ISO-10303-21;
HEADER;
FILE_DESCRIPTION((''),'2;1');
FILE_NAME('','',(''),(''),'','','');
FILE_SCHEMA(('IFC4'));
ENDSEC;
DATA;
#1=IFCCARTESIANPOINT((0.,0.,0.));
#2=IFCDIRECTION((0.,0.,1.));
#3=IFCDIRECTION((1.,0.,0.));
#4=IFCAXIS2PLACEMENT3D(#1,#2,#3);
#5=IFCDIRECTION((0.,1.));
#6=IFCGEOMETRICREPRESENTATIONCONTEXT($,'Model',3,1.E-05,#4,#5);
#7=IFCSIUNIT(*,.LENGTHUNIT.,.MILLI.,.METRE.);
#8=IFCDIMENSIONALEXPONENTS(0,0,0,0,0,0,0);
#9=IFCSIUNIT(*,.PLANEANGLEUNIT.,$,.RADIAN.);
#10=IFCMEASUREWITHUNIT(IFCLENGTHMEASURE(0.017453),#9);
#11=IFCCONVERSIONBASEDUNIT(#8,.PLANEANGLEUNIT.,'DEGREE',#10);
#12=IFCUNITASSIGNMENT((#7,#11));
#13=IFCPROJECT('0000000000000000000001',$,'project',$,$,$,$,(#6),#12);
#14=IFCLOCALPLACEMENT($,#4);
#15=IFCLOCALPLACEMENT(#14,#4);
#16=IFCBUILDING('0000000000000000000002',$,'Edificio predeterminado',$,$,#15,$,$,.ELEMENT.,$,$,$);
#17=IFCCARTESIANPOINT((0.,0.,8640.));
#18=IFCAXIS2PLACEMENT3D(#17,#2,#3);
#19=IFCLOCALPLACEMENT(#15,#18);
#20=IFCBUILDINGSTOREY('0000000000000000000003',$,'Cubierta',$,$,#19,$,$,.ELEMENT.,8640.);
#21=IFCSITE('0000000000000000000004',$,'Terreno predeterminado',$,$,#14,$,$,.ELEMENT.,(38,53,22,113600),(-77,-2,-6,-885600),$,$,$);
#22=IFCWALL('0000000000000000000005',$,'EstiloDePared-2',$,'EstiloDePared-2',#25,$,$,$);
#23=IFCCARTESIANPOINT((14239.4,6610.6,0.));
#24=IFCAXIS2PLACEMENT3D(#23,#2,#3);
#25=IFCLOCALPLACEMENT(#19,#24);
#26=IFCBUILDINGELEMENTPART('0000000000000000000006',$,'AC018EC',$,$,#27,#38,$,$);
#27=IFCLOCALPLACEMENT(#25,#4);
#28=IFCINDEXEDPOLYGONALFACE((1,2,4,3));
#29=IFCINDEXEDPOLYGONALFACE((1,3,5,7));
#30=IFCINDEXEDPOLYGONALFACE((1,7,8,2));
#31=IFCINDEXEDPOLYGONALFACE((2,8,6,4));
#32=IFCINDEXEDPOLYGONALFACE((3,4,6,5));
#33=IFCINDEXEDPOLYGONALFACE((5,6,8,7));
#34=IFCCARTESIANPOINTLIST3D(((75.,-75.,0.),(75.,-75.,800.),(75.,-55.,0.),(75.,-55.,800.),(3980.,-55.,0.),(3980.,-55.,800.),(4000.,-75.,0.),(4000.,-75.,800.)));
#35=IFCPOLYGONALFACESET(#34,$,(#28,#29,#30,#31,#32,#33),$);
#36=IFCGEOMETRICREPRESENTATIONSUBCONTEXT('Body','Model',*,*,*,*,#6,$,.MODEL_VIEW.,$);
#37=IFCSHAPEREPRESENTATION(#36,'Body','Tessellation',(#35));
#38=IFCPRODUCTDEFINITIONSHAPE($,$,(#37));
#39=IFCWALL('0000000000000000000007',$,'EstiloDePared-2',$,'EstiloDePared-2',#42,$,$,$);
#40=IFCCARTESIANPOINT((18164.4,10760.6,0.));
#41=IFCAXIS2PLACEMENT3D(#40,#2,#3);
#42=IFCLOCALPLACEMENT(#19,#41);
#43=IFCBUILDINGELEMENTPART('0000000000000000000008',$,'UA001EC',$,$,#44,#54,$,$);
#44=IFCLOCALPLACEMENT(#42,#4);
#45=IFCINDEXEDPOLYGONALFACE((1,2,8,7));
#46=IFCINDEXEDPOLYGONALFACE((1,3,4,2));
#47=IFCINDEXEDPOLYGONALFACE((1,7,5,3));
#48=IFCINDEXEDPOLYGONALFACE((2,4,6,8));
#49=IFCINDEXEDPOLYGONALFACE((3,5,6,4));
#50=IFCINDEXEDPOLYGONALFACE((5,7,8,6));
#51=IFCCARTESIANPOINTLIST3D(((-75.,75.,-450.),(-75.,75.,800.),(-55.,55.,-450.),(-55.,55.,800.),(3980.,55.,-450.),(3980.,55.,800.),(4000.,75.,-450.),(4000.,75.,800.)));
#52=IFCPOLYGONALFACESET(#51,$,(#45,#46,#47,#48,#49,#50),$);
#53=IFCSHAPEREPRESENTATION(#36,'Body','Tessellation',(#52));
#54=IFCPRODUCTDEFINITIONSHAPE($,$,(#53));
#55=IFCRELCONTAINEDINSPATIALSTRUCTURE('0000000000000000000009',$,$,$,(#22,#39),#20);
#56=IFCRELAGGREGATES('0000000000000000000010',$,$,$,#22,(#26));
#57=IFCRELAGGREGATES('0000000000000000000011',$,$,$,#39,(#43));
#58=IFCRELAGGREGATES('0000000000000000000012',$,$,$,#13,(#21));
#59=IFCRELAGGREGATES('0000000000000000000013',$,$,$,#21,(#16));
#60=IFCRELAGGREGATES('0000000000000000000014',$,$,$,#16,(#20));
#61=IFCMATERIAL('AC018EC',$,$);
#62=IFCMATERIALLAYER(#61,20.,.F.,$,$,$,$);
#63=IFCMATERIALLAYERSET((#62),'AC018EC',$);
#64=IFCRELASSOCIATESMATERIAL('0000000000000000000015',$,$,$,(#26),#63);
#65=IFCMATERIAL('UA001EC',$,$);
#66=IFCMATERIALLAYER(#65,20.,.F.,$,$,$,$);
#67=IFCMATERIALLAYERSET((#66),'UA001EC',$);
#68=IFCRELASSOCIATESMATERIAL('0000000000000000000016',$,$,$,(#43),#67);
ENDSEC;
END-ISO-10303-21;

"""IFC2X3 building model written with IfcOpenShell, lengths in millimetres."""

from ifc_helpers import new_model, entity, si_unit, converted_unit, direction, frame, origin_with_axes, place, context, subcontext, project, spatial, polyline, outline, extrude, material, layer, layer_set, layer_usage, element, aggregate, save


model = new_model("IFC2X3")

# Units and contexts
model_context = context("Model", 3, precision=1e-05, world=origin_with_axes(), true_north=direction((0.0, 1.0)))
body_context = subcontext(model_context, "Body", "Model", "MODEL_VIEW")
ifc_project = project(units=[si_unit("LENGTHUNIT", "METRE", prefix="MILLI"), converted_unit("PLANEANGLEUNIT", "DEGREE", entity("IfcLengthMeasure", 0.017453), si_unit("PLANEANGLEUNIT", "RADIAN"), dimensions=[0, 0, 0, 0, 0, 0, 0])], contexts=[model_context])

# Site, building, storey
site_placement = place(None, origin_with_axes())
site = spatial("IfcSite", under=ifc_project, at=site_placement, Name="Terreno predeterminado", CompositionType="ELEMENT", RefLatitude=(38, 53, 22, 113600), RefLongitude=(-77, -2, -6, -885600))
building_placement = place(site_placement, origin_with_axes())
building = spatial("IfcBuilding", under=site, at=building_placement, Name="Edificio predeterminado", CompositionType="ELEMENT")
storey_placement = place(building_placement, frame((0.0, 0.0, 8640.0), z_axis=(0.0, 0.0, 1.0), x_axis=(1.0, 0.0, 0.0)))
storey = spatial("IfcBuildingStorey", under=building, at=storey_placement, Name="Cubierta", CompositionType="ELEMENT", Elevation=8640.0)

# Walls, building element parts
wall_1_placement = place(storey_placement, frame((14239.4, 6610.6, 0.0), z_axis=(0.0, 0.0, 1.0), x_axis=(1.0, 0.0, 0.0)))
wall_1 = element("IfcWall", 1, at=wall_1_placement, inside=storey, Name="EstiloDePared-2", ObjectType="EstiloDePared-2")
ifc_material_1 = material(Name="AC018EC")
ifc_layer_1 = layer(ifc_material_1, 20.0, ventilated=False)
ifc_layer_set_1 = layer_set([ifc_layer_1], Name="AC018EC")
ifc_layer_usage_1 = layer_usage(ifc_layer_set_1, "AXIS2", "NEGATIVE", 55.0)
building_element_part_1_placement = place(wall_1_placement, origin_with_axes())
building_element_part_1 = element("IfcBuildingElementPart", 2, at=building_element_part_1_placement, material=ifc_layer_usage_1, Name="AC018EC", context=body_context, shape_type="SweptSolid", body=[
    extrude(outline(polyline([(3980.0, -55.0), (4000.0, -75.0), (75.0, -75.0), (75.0, -55.0), (3980.0, -55.0)])), origin_with_axes(), (0.0, 0.0, 1.0), 800.0),
])
aggregate(wall_1, [building_element_part_1])
wall_2_placement = place(storey_placement, frame((18164.4, 10760.6, 0.0), z_axis=(0.0, 0.0, 1.0), x_axis=(1.0, 0.0, 0.0)))
wall_2 = element("IfcWall", 3, at=wall_2_placement, inside=storey, Name="EstiloDePared-2", ObjectType="EstiloDePared-2")
ifc_material_2 = material(Name="UA001EC")
ifc_layer_2 = layer(ifc_material_2, 20.0, ventilated=False)
ifc_layer_set_2 = layer_set([ifc_layer_2], Name="UA001EC")
ifc_layer_usage_2 = layer_usage(ifc_layer_set_2, "AXIS2", "NEGATIVE", -75.0)
building_element_part_2_placement = place(wall_2_placement, origin_with_axes())
building_element_part_2 = element("IfcBuildingElementPart", 4, at=building_element_part_2_placement, material=ifc_layer_usage_2, Name="UA001EC", context=body_context, shape_type="SweptSolid", body=[
    extrude(outline(polyline([(4000.0, 75.0), (3980.0, 55.0), (-55.0, 55.0), (-75.0, 75.0), (4000.0, 75.0)])), frame((0.0, 0.0, -450.0), z_axis=(0.0, 0.0, 1.0), x_axis=(1.0, 0.0, 0.0)), (0.0, 0.0, 1.0), 1250.0),
])
aggregate(wall_2, [building_element_part_2])

save(model, "model.ifc")
